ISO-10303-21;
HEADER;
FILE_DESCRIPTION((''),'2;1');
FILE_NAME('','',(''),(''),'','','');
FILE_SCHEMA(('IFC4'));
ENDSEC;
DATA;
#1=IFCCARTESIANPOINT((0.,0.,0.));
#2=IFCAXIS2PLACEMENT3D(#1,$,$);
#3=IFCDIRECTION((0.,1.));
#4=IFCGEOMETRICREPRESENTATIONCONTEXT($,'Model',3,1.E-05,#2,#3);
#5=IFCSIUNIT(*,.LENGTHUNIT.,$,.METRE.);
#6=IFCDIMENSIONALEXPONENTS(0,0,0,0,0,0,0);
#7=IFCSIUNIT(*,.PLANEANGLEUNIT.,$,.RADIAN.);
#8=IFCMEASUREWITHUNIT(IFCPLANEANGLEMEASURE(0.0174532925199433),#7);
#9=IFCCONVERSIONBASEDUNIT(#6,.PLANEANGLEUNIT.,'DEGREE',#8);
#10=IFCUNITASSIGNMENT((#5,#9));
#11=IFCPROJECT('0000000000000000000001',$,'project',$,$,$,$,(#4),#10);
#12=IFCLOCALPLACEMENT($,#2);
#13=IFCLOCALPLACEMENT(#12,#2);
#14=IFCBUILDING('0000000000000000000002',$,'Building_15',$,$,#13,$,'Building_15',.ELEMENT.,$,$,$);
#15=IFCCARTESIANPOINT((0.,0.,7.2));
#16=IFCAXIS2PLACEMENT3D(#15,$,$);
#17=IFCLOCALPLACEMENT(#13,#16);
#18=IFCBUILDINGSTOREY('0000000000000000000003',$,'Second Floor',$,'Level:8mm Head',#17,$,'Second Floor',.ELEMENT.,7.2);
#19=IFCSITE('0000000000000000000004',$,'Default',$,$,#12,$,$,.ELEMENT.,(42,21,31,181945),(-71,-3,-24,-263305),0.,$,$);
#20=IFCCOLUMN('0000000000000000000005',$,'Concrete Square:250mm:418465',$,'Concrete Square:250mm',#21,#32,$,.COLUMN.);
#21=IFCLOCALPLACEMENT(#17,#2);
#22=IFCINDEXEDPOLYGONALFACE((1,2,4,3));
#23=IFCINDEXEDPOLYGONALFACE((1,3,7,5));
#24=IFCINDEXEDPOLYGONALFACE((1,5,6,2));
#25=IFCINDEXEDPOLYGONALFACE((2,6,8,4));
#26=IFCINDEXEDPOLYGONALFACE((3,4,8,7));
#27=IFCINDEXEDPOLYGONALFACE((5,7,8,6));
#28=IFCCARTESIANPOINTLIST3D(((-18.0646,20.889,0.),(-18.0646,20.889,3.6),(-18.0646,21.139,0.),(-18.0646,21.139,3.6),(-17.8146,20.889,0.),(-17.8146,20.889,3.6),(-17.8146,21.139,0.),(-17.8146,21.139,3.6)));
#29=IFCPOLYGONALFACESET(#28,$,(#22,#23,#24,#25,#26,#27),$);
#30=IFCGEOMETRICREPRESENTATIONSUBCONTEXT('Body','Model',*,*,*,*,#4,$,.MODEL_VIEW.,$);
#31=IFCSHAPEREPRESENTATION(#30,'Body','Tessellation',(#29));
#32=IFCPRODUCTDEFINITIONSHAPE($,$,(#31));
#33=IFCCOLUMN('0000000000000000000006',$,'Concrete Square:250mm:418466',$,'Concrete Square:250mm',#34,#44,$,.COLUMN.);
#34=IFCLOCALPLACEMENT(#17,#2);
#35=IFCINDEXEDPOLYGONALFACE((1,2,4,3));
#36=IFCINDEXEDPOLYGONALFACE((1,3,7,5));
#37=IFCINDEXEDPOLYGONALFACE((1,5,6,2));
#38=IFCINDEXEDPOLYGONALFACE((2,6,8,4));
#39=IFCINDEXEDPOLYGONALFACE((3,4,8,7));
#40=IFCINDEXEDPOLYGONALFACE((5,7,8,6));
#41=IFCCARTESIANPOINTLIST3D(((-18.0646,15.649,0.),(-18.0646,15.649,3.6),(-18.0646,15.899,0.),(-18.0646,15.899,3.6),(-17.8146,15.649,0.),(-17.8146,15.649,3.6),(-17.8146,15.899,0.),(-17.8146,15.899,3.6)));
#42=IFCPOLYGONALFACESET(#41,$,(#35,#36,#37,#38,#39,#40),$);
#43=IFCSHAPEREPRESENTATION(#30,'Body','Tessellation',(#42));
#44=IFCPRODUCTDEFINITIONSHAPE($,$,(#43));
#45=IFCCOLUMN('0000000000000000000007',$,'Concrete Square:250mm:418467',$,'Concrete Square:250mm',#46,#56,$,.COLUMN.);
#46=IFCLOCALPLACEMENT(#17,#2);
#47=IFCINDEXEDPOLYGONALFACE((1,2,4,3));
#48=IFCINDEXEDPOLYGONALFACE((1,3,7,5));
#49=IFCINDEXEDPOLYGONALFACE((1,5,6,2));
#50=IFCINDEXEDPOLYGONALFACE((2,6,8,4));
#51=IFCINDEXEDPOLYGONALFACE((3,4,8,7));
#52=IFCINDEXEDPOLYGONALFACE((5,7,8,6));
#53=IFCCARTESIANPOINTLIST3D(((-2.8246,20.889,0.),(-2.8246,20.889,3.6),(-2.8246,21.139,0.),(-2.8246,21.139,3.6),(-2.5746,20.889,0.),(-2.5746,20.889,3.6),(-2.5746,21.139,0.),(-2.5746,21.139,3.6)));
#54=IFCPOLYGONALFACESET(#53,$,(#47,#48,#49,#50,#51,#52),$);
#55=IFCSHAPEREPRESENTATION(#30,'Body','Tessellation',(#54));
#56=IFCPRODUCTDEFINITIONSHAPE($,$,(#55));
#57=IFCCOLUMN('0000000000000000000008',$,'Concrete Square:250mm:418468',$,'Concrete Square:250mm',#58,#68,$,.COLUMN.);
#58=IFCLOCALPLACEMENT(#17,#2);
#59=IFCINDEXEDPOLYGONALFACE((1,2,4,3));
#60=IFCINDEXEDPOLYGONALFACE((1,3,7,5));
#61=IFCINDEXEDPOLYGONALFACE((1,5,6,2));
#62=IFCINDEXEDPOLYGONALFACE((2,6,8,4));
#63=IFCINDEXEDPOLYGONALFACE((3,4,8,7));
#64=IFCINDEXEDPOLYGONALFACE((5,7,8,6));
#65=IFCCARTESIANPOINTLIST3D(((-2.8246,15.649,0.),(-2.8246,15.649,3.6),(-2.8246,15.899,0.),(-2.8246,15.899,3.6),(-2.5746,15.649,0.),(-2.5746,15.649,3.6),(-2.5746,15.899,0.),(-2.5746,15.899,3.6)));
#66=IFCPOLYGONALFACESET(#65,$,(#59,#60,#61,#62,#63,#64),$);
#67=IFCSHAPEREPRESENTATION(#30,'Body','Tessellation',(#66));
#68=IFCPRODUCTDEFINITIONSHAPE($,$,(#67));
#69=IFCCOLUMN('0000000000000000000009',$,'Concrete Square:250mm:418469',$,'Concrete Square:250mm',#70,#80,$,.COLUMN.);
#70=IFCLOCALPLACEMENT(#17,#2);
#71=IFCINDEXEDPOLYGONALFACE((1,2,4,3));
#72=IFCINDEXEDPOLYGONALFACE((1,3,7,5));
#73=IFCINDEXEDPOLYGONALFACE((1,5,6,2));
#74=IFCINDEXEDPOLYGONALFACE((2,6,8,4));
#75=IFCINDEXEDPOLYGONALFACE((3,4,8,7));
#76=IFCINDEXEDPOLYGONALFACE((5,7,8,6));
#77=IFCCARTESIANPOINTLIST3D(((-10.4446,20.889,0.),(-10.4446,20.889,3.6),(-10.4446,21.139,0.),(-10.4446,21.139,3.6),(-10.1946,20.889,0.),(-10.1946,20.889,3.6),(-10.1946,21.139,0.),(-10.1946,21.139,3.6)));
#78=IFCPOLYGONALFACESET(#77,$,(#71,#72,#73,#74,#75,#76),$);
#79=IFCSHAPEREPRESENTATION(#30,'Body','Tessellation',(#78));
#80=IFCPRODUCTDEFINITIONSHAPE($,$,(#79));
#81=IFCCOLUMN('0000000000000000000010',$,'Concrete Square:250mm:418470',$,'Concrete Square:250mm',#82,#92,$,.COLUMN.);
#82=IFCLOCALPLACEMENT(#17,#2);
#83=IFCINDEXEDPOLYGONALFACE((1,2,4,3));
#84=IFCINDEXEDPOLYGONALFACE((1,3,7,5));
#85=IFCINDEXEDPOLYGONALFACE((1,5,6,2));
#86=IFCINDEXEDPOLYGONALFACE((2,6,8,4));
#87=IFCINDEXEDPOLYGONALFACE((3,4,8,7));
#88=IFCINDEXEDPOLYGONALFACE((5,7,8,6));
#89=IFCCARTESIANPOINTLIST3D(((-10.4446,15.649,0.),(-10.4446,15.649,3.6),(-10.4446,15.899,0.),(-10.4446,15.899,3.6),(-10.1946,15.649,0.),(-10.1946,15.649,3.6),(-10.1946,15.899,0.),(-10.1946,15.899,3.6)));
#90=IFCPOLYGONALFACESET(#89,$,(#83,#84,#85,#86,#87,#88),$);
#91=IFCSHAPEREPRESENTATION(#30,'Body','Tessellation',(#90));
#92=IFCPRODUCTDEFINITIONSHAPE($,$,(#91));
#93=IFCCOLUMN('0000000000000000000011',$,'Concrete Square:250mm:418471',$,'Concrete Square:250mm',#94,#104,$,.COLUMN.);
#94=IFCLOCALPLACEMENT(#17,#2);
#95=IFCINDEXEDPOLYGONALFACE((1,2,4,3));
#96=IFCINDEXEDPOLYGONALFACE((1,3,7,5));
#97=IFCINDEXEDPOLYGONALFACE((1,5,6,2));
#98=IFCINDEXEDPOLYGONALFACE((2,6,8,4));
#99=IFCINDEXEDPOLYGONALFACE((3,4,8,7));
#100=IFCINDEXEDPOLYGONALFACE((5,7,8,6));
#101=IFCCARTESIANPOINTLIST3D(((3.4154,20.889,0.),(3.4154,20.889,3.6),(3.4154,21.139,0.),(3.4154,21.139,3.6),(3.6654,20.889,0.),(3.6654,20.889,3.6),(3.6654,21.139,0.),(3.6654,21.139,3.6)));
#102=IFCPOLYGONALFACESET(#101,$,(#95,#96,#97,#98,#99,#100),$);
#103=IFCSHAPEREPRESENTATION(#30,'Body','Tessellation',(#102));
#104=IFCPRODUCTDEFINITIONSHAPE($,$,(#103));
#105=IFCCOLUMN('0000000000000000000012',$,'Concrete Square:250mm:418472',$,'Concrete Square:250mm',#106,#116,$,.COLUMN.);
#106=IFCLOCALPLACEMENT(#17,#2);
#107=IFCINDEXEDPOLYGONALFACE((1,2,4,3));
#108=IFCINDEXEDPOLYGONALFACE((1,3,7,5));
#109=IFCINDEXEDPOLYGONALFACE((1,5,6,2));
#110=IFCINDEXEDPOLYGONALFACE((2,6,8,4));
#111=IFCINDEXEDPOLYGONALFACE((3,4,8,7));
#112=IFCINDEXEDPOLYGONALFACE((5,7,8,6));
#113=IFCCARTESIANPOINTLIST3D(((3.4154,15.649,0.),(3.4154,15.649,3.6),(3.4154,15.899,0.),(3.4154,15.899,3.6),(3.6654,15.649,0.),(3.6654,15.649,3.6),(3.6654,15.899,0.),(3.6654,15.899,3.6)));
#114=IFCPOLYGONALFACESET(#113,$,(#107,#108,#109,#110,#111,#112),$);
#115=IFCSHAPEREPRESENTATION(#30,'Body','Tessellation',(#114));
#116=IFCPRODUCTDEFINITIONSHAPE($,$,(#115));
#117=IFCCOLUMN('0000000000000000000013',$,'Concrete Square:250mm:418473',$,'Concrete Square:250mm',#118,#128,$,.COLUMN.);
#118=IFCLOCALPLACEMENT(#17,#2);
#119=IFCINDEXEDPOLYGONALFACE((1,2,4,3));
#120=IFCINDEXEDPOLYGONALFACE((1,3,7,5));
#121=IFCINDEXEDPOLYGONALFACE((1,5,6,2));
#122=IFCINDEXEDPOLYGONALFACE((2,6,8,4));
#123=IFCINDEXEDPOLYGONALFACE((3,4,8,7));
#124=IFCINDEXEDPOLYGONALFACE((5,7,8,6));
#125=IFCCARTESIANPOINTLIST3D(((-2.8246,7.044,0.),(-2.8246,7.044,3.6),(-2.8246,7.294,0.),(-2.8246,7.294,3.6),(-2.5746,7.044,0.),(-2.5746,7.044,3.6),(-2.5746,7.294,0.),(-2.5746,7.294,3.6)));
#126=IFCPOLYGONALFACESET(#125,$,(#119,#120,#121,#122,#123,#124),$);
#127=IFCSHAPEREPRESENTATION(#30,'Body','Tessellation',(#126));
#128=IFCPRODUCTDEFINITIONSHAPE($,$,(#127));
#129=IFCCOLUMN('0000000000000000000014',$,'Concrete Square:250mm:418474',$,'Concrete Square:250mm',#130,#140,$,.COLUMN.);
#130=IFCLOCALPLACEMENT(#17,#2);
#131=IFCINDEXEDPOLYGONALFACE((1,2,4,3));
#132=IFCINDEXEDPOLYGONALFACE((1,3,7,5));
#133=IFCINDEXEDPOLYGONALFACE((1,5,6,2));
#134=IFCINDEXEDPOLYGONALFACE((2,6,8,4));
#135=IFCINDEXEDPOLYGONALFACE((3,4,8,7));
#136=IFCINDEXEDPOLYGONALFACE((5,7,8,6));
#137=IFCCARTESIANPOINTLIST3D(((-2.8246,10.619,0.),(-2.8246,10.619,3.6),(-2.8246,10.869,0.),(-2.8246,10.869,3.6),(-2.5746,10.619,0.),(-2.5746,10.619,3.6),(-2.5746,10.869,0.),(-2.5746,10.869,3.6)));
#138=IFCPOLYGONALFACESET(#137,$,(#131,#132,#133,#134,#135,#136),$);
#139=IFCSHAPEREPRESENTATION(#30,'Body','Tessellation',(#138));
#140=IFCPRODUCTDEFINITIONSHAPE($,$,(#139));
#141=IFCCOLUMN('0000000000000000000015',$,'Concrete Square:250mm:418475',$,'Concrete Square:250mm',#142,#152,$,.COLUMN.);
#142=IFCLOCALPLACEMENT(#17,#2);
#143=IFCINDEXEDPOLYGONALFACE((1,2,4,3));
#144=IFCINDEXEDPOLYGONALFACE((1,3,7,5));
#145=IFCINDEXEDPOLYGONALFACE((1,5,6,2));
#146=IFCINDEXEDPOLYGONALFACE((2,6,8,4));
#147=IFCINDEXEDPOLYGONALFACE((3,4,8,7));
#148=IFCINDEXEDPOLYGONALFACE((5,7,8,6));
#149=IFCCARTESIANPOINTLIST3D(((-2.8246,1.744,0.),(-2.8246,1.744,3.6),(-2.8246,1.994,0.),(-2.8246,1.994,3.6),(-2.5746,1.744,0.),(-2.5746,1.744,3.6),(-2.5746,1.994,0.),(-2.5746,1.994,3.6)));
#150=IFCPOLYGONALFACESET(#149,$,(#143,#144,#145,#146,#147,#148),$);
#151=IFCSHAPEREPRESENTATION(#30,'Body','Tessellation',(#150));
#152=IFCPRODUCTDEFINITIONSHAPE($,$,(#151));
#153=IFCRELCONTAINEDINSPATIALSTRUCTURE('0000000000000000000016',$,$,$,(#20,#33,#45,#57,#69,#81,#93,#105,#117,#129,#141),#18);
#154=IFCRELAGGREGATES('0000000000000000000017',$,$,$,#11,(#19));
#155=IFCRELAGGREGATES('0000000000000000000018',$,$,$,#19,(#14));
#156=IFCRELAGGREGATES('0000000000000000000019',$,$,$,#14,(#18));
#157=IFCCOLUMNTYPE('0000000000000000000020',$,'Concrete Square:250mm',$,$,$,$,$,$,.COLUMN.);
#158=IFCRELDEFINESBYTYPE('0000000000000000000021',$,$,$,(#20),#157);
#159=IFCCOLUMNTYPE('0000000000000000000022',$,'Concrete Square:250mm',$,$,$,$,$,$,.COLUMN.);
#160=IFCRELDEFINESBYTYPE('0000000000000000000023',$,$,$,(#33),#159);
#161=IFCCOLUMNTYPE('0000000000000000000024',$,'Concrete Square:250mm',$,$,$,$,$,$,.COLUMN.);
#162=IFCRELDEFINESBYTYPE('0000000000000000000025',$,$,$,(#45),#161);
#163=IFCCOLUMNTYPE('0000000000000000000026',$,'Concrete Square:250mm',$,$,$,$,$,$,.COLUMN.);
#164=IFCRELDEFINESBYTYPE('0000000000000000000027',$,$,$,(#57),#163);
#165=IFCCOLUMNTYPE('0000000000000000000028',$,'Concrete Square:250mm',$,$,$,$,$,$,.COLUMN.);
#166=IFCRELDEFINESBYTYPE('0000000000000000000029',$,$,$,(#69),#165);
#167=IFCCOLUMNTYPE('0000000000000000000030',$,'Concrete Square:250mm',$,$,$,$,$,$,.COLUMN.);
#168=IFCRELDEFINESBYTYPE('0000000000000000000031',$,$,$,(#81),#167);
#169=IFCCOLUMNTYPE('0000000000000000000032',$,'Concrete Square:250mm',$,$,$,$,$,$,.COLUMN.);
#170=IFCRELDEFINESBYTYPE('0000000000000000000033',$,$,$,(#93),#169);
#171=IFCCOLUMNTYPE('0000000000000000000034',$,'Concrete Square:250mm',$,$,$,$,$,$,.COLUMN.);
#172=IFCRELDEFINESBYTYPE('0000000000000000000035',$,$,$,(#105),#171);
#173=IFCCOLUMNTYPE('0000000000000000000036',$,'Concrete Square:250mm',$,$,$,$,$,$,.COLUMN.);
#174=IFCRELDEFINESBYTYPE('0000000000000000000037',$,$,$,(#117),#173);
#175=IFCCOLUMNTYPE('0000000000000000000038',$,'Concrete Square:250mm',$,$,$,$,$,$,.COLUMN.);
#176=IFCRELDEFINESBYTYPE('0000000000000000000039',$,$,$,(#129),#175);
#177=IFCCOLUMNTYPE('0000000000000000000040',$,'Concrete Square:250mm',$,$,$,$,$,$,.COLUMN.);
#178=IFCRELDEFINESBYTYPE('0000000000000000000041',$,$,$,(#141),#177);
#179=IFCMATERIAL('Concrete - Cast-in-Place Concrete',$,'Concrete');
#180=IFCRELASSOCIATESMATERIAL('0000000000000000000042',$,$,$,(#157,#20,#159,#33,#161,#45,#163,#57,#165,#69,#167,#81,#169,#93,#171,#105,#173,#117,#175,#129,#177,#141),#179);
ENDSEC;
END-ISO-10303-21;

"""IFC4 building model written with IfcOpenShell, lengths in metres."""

from ifc_helpers import new_model, entity, si_unit, converted_unit, direction, frame, origin, place, context, subcontext, project, spatial, indexed_curve, outline, extrude, source, transform, mapped, material, type_object, type_shapes, element, save


model = new_model("IFC4")

# Units and contexts
model_context = context("Model", 3, precision=1e-05, world=origin(), true_north=direction((0.0, 1.0)))
body_context = subcontext(model_context, "Body", "Model", "MODEL_VIEW")
ifc_project = project(units=[si_unit("LENGTHUNIT", "METRE"), converted_unit("PLANEANGLEUNIT", "DEGREE", entity("IfcPlaneAngleMeasure", 0.0174532925199433), si_unit("PLANEANGLEUNIT", "RADIAN"), dimensions=[0, 0, 0, 0, 0, 0, 0])], contexts=[model_context])

# Site, building, storey
site_placement = place(None, origin())
site = spatial("IfcSite", under=ifc_project, at=site_placement, Name="Default", CompositionType="ELEMENT", RefLatitude=(42, 21, 31, 181945), RefLongitude=(-71, -3, -24, -263305), RefElevation=0.0)
building_placement = place(site_placement, origin())
building = spatial("IfcBuilding", under=site, at=building_placement, Name="Building_15", LongName="Building_15", CompositionType="ELEMENT")
storey_placement = place(building_placement, frame((0.0, 0.0, 7.2)))
storey = spatial("IfcBuildingStorey", under=building, at=storey_placement, Name="Second Floor", ObjectType="Level:8mm Head", LongName="Second Floor", CompositionType="ELEMENT", Elevation=7.2)

# Columns
ifc_material_1 = material(Name="Concrete - Cast-in-Place Concrete", Category="Concrete")
column_type_1 = type_object("IfcColumnType", Name="Concrete Square:250mm", PredefinedType="COLUMN", material=ifc_material_1)
shared_shape_1 = source(origin(), body_context, "Body", "SweptSolid", [
    extrude(outline(indexed_curve([(-0.125, -0.125), (0.125, -0.125), (0.125, 0.125), (-0.125, 0.125), (-0.125, -0.125)], self_intersect=False)), frame((-17.9396, 21.014, 7.2), z_axis=(0.0, 0.0, 1.0), x_axis=(-1.0, 0.0, 0.0)), (0.0, 0.0, 1.0), 3.6),
])
type_shapes(column_type_1, [shared_shape_1])
column_1_placement = place(storey_placement, frame((0.0, 0.0, -7.2)))
element("IfcColumn", 1, at=column_1_placement, inside=storey, type_object=column_type_1, material=ifc_material_1, Name="Concrete Square:250mm:418465", ObjectType="Concrete Square:250mm", PredefinedType="COLUMN", context=body_context, shape_type="MappedRepresentation", body=[
    mapped(shared_shape_1, transform((0.0, 0.0, 0.0), scale=1.0)),
])
column_type_2 = type_object("IfcColumnType", Name="Concrete Square:250mm", PredefinedType="COLUMN", material=ifc_material_1)
shared_shape_2 = source(origin(), body_context, "Body", "SweptSolid", [
    extrude(outline(indexed_curve([(-0.125, -0.125), (0.125, -0.125), (0.125, 0.125), (-0.125, 0.125), (-0.125, -0.125)], self_intersect=False)), frame((-17.9396, 15.774, 7.2), z_axis=(0.0, 0.0, 1.0), x_axis=(-1.0, 0.0, 0.0)), (0.0, 0.0, 1.0), 3.6),
])
type_shapes(column_type_2, [shared_shape_2])
column_2_placement = place(storey_placement, frame((0.0, 0.0, -7.2)))
element("IfcColumn", 2, at=column_2_placement, inside=storey, type_object=column_type_2, material=ifc_material_1, Name="Concrete Square:250mm:418466", ObjectType="Concrete Square:250mm", PredefinedType="COLUMN", context=body_context, shape_type="MappedRepresentation", body=[
    mapped(shared_shape_2, transform((0.0, 0.0, 0.0), scale=1.0)),
])
column_type_3 = type_object("IfcColumnType", Name="Concrete Square:250mm", PredefinedType="COLUMN", material=ifc_material_1)
shared_shape_3 = source(origin(), body_context, "Body", "SweptSolid", [
    extrude(outline(indexed_curve([(-0.125, -0.125), (0.125, -0.125), (0.125, 0.125), (-0.125, 0.125), (-0.125, -0.125)], self_intersect=False)), frame((-2.6996, 21.014, 7.2), z_axis=(0.0, 0.0, 1.0), x_axis=(-1.0, 0.0, 0.0)), (0.0, 0.0, 1.0), 3.6),
])
type_shapes(column_type_3, [shared_shape_3])
column_3_placement = place(storey_placement, frame((0.0, 0.0, -7.2)))
element("IfcColumn", 3, at=column_3_placement, inside=storey, type_object=column_type_3, material=ifc_material_1, Name="Concrete Square:250mm:418467", ObjectType="Concrete Square:250mm", PredefinedType="COLUMN", context=body_context, shape_type="MappedRepresentation", body=[
    mapped(shared_shape_3, transform((0.0, 0.0, 0.0), scale=1.0)),
])
column_type_4 = type_object("IfcColumnType", Name="Concrete Square:250mm", PredefinedType="COLUMN", material=ifc_material_1)
shared_shape_4 = source(origin(), body_context, "Body", "SweptSolid", [
    extrude(outline(indexed_curve([(-0.125, -0.125), (0.125, -0.125), (0.125, 0.125), (-0.125, 0.125), (-0.125, -0.125)], self_intersect=False)), frame((-2.6996, 15.774, 7.2), z_axis=(0.0, 0.0, 1.0), x_axis=(-1.0, 0.0, 0.0)), (0.0, 0.0, 1.0), 3.6),
])
type_shapes(column_type_4, [shared_shape_4])
column_4_placement = place(storey_placement, frame((0.0, 0.0, -7.2)))
element("IfcColumn", 4, at=column_4_placement, inside=storey, type_object=column_type_4, material=ifc_material_1, Name="Concrete Square:250mm:418468", ObjectType="Concrete Square:250mm", PredefinedType="COLUMN", context=body_context, shape_type="MappedRepresentation", body=[
    mapped(shared_shape_4, transform((0.0, 0.0, 0.0), scale=1.0)),
])
column_type_5 = type_object("IfcColumnType", Name="Concrete Square:250mm", PredefinedType="COLUMN", material=ifc_material_1)
shared_shape_5 = source(origin(), body_context, "Body", "SweptSolid", [
    extrude(outline(indexed_curve([(-0.125, -0.125), (0.125, -0.125), (0.125, 0.125), (-0.125, 0.125), (-0.125, -0.125)], self_intersect=False)), frame((-10.3196, 21.014, 7.2), z_axis=(0.0, 0.0, 1.0), x_axis=(-1.0, 0.0, 0.0)), (0.0, 0.0, 1.0), 3.6),
])
type_shapes(column_type_5, [shared_shape_5])
column_5_placement = place(storey_placement, frame((0.0, 0.0, -7.2)))
element("IfcColumn", 5, at=column_5_placement, inside=storey, type_object=column_type_5, material=ifc_material_1, Name="Concrete Square:250mm:418469", ObjectType="Concrete Square:250mm", PredefinedType="COLUMN", context=body_context, shape_type="MappedRepresentation", body=[
    mapped(shared_shape_5, transform((0.0, 0.0, 0.0), scale=1.0)),
])
column_type_6 = type_object("IfcColumnType", Name="Concrete Square:250mm", PredefinedType="COLUMN", material=ifc_material_1)
shared_shape_6 = source(origin(), body_context, "Body", "SweptSolid", [
    extrude(outline(indexed_curve([(-0.125, -0.125), (0.125, -0.125), (0.125, 0.125), (-0.125, 0.125), (-0.125, -0.125)], self_intersect=False)), frame((-10.3196, 15.774, 7.2), z_axis=(0.0, 0.0, 1.0), x_axis=(-1.0, 0.0, 0.0)), (0.0, 0.0, 1.0), 3.6),
])
type_shapes(column_type_6, [shared_shape_6])
column_6_placement = place(storey_placement, frame((0.0, 0.0, -7.2)))
element("IfcColumn", 6, at=column_6_placement, inside=storey, type_object=column_type_6, material=ifc_material_1, Name="Concrete Square:250mm:418470", ObjectType="Concrete Square:250mm", PredefinedType="COLUMN", context=body_context, shape_type="MappedRepresentation", body=[
    mapped(shared_shape_6, transform((0.0, 0.0, 0.0), scale=1.0)),
])
column_type_7 = type_object("IfcColumnType", Name="Concrete Square:250mm", PredefinedType="COLUMN", material=ifc_material_1)
shared_shape_7 = source(origin(), body_context, "Body", "SweptSolid", [
    extrude(outline(indexed_curve([(-0.125, -0.125), (0.125, -0.125), (0.125, 0.125), (-0.125, 0.125), (-0.125, -0.125)], self_intersect=False)), frame((3.5404, 21.014, 7.2), z_axis=(0.0, 0.0, 1.0), x_axis=(-1.0, 0.0, 0.0)), (0.0, 0.0, 1.0), 3.6),
])
type_shapes(column_type_7, [shared_shape_7])
column_7_placement = place(storey_placement, frame((0.0, 0.0, -7.2)))
element("IfcColumn", 7, at=column_7_placement, inside=storey, type_object=column_type_7, material=ifc_material_1, Name="Concrete Square:250mm:418471", ObjectType="Concrete Square:250mm", PredefinedType="COLUMN", context=body_context, shape_type="MappedRepresentation", body=[
    mapped(shared_shape_7, transform((0.0, 0.0, 0.0), scale=1.0)),
])
column_type_8 = type_object("IfcColumnType", Name="Concrete Square:250mm", PredefinedType="COLUMN", material=ifc_material_1)
shared_shape_8 = source(origin(), body_context, "Body", "SweptSolid", [
    extrude(outline(indexed_curve([(-0.125, -0.125), (0.125, -0.125), (0.125, 0.125), (-0.125, 0.125), (-0.125, -0.125)], self_intersect=False)), frame((3.5404, 15.774, 7.2), z_axis=(0.0, 0.0, 1.0), x_axis=(-1.0, 0.0, 0.0)), (0.0, 0.0, 1.0), 3.6),
])
type_shapes(column_type_8, [shared_shape_8])
column_8_placement = place(storey_placement, frame((0.0, 0.0, -7.2)))
element("IfcColumn", 8, at=column_8_placement, inside=storey, type_object=column_type_8, material=ifc_material_1, Name="Concrete Square:250mm:418472", ObjectType="Concrete Square:250mm", PredefinedType="COLUMN", context=body_context, shape_type="MappedRepresentation", body=[
    mapped(shared_shape_8, transform((0.0, 0.0, 0.0), scale=1.0)),
])
column_type_9 = type_object("IfcColumnType", Name="Concrete Square:250mm", PredefinedType="COLUMN", material=ifc_material_1)
shared_shape_9 = source(origin(), body_context, "Body", "SweptSolid", [
    extrude(outline(indexed_curve([(-0.125, -0.125), (0.125, -0.125), (0.125, 0.125), (-0.125, 0.125), (-0.125, -0.125)], self_intersect=False)), frame((-2.6996, 7.169, 7.2), z_axis=(0.0, 0.0, 1.0), x_axis=(-1.0, 0.0, 0.0)), (0.0, 0.0, 1.0), 3.6),
])
type_shapes(column_type_9, [shared_shape_9])
column_9_placement = place(storey_placement, frame((0.0, 0.0, -7.2)))
element("IfcColumn", 9, at=column_9_placement, inside=storey, type_object=column_type_9, material=ifc_material_1, Name="Concrete Square:250mm:418473", ObjectType="Concrete Square:250mm", PredefinedType="COLUMN", context=body_context, shape_type="MappedRepresentation", body=[
    mapped(shared_shape_9, transform((0.0, 0.0, 0.0), scale=1.0)),
])
column_type_10 = type_object("IfcColumnType", Name="Concrete Square:250mm", PredefinedType="COLUMN", material=ifc_material_1)
shared_shape_10 = source(origin(), body_context, "Body", "SweptSolid", [
    extrude(outline(indexed_curve([(-0.125, -0.125), (0.125, -0.125), (0.125, 0.125), (-0.125, 0.125), (-0.125, -0.125)], self_intersect=False)), frame((-2.6996, 10.744, 7.2), z_axis=(0.0, 0.0, 1.0), x_axis=(-1.0, 0.0, 0.0)), (0.0, 0.0, 1.0), 3.6),
])
type_shapes(column_type_10, [shared_shape_10])
column_10_placement = place(storey_placement, frame((0.0, 0.0, -7.2)))
element("IfcColumn", 10, at=column_10_placement, inside=storey, type_object=column_type_10, material=ifc_material_1, Name="Concrete Square:250mm:418474", ObjectType="Concrete Square:250mm", PredefinedType="COLUMN", context=body_context, shape_type="MappedRepresentation", body=[
    mapped(shared_shape_10, transform((0.0, 0.0, 0.0), scale=1.0)),
])
column_type_11 = type_object("IfcColumnType", Name="Concrete Square:250mm", PredefinedType="COLUMN", material=ifc_material_1)
shared_shape_11 = source(origin(), body_context, "Body", "SweptSolid", [
    extrude(outline(indexed_curve([(-0.125, -0.125), (0.125, -0.125), (0.125, 0.125), (-0.125, 0.125), (-0.125, -0.125)], self_intersect=False)), frame((-2.6996, 1.869, 7.2), z_axis=(0.0, 0.0, 1.0), x_axis=(-1.0, 0.0, 0.0)), (0.0, 0.0, 1.0), 3.6),
])
type_shapes(column_type_11, [shared_shape_11])
column_11_placement = place(storey_placement, frame((0.0, 0.0, -7.2)))
element("IfcColumn", 11, at=column_11_placement, inside=storey, type_object=column_type_11, material=ifc_material_1, Name="Concrete Square:250mm:418475", ObjectType="Concrete Square:250mm", PredefinedType="COLUMN", context=body_context, shape_type="MappedRepresentation", body=[
    mapped(shared_shape_11, transform((0.0, 0.0, 0.0), scale=1.0)),
])

save(model, "model.ifc")
